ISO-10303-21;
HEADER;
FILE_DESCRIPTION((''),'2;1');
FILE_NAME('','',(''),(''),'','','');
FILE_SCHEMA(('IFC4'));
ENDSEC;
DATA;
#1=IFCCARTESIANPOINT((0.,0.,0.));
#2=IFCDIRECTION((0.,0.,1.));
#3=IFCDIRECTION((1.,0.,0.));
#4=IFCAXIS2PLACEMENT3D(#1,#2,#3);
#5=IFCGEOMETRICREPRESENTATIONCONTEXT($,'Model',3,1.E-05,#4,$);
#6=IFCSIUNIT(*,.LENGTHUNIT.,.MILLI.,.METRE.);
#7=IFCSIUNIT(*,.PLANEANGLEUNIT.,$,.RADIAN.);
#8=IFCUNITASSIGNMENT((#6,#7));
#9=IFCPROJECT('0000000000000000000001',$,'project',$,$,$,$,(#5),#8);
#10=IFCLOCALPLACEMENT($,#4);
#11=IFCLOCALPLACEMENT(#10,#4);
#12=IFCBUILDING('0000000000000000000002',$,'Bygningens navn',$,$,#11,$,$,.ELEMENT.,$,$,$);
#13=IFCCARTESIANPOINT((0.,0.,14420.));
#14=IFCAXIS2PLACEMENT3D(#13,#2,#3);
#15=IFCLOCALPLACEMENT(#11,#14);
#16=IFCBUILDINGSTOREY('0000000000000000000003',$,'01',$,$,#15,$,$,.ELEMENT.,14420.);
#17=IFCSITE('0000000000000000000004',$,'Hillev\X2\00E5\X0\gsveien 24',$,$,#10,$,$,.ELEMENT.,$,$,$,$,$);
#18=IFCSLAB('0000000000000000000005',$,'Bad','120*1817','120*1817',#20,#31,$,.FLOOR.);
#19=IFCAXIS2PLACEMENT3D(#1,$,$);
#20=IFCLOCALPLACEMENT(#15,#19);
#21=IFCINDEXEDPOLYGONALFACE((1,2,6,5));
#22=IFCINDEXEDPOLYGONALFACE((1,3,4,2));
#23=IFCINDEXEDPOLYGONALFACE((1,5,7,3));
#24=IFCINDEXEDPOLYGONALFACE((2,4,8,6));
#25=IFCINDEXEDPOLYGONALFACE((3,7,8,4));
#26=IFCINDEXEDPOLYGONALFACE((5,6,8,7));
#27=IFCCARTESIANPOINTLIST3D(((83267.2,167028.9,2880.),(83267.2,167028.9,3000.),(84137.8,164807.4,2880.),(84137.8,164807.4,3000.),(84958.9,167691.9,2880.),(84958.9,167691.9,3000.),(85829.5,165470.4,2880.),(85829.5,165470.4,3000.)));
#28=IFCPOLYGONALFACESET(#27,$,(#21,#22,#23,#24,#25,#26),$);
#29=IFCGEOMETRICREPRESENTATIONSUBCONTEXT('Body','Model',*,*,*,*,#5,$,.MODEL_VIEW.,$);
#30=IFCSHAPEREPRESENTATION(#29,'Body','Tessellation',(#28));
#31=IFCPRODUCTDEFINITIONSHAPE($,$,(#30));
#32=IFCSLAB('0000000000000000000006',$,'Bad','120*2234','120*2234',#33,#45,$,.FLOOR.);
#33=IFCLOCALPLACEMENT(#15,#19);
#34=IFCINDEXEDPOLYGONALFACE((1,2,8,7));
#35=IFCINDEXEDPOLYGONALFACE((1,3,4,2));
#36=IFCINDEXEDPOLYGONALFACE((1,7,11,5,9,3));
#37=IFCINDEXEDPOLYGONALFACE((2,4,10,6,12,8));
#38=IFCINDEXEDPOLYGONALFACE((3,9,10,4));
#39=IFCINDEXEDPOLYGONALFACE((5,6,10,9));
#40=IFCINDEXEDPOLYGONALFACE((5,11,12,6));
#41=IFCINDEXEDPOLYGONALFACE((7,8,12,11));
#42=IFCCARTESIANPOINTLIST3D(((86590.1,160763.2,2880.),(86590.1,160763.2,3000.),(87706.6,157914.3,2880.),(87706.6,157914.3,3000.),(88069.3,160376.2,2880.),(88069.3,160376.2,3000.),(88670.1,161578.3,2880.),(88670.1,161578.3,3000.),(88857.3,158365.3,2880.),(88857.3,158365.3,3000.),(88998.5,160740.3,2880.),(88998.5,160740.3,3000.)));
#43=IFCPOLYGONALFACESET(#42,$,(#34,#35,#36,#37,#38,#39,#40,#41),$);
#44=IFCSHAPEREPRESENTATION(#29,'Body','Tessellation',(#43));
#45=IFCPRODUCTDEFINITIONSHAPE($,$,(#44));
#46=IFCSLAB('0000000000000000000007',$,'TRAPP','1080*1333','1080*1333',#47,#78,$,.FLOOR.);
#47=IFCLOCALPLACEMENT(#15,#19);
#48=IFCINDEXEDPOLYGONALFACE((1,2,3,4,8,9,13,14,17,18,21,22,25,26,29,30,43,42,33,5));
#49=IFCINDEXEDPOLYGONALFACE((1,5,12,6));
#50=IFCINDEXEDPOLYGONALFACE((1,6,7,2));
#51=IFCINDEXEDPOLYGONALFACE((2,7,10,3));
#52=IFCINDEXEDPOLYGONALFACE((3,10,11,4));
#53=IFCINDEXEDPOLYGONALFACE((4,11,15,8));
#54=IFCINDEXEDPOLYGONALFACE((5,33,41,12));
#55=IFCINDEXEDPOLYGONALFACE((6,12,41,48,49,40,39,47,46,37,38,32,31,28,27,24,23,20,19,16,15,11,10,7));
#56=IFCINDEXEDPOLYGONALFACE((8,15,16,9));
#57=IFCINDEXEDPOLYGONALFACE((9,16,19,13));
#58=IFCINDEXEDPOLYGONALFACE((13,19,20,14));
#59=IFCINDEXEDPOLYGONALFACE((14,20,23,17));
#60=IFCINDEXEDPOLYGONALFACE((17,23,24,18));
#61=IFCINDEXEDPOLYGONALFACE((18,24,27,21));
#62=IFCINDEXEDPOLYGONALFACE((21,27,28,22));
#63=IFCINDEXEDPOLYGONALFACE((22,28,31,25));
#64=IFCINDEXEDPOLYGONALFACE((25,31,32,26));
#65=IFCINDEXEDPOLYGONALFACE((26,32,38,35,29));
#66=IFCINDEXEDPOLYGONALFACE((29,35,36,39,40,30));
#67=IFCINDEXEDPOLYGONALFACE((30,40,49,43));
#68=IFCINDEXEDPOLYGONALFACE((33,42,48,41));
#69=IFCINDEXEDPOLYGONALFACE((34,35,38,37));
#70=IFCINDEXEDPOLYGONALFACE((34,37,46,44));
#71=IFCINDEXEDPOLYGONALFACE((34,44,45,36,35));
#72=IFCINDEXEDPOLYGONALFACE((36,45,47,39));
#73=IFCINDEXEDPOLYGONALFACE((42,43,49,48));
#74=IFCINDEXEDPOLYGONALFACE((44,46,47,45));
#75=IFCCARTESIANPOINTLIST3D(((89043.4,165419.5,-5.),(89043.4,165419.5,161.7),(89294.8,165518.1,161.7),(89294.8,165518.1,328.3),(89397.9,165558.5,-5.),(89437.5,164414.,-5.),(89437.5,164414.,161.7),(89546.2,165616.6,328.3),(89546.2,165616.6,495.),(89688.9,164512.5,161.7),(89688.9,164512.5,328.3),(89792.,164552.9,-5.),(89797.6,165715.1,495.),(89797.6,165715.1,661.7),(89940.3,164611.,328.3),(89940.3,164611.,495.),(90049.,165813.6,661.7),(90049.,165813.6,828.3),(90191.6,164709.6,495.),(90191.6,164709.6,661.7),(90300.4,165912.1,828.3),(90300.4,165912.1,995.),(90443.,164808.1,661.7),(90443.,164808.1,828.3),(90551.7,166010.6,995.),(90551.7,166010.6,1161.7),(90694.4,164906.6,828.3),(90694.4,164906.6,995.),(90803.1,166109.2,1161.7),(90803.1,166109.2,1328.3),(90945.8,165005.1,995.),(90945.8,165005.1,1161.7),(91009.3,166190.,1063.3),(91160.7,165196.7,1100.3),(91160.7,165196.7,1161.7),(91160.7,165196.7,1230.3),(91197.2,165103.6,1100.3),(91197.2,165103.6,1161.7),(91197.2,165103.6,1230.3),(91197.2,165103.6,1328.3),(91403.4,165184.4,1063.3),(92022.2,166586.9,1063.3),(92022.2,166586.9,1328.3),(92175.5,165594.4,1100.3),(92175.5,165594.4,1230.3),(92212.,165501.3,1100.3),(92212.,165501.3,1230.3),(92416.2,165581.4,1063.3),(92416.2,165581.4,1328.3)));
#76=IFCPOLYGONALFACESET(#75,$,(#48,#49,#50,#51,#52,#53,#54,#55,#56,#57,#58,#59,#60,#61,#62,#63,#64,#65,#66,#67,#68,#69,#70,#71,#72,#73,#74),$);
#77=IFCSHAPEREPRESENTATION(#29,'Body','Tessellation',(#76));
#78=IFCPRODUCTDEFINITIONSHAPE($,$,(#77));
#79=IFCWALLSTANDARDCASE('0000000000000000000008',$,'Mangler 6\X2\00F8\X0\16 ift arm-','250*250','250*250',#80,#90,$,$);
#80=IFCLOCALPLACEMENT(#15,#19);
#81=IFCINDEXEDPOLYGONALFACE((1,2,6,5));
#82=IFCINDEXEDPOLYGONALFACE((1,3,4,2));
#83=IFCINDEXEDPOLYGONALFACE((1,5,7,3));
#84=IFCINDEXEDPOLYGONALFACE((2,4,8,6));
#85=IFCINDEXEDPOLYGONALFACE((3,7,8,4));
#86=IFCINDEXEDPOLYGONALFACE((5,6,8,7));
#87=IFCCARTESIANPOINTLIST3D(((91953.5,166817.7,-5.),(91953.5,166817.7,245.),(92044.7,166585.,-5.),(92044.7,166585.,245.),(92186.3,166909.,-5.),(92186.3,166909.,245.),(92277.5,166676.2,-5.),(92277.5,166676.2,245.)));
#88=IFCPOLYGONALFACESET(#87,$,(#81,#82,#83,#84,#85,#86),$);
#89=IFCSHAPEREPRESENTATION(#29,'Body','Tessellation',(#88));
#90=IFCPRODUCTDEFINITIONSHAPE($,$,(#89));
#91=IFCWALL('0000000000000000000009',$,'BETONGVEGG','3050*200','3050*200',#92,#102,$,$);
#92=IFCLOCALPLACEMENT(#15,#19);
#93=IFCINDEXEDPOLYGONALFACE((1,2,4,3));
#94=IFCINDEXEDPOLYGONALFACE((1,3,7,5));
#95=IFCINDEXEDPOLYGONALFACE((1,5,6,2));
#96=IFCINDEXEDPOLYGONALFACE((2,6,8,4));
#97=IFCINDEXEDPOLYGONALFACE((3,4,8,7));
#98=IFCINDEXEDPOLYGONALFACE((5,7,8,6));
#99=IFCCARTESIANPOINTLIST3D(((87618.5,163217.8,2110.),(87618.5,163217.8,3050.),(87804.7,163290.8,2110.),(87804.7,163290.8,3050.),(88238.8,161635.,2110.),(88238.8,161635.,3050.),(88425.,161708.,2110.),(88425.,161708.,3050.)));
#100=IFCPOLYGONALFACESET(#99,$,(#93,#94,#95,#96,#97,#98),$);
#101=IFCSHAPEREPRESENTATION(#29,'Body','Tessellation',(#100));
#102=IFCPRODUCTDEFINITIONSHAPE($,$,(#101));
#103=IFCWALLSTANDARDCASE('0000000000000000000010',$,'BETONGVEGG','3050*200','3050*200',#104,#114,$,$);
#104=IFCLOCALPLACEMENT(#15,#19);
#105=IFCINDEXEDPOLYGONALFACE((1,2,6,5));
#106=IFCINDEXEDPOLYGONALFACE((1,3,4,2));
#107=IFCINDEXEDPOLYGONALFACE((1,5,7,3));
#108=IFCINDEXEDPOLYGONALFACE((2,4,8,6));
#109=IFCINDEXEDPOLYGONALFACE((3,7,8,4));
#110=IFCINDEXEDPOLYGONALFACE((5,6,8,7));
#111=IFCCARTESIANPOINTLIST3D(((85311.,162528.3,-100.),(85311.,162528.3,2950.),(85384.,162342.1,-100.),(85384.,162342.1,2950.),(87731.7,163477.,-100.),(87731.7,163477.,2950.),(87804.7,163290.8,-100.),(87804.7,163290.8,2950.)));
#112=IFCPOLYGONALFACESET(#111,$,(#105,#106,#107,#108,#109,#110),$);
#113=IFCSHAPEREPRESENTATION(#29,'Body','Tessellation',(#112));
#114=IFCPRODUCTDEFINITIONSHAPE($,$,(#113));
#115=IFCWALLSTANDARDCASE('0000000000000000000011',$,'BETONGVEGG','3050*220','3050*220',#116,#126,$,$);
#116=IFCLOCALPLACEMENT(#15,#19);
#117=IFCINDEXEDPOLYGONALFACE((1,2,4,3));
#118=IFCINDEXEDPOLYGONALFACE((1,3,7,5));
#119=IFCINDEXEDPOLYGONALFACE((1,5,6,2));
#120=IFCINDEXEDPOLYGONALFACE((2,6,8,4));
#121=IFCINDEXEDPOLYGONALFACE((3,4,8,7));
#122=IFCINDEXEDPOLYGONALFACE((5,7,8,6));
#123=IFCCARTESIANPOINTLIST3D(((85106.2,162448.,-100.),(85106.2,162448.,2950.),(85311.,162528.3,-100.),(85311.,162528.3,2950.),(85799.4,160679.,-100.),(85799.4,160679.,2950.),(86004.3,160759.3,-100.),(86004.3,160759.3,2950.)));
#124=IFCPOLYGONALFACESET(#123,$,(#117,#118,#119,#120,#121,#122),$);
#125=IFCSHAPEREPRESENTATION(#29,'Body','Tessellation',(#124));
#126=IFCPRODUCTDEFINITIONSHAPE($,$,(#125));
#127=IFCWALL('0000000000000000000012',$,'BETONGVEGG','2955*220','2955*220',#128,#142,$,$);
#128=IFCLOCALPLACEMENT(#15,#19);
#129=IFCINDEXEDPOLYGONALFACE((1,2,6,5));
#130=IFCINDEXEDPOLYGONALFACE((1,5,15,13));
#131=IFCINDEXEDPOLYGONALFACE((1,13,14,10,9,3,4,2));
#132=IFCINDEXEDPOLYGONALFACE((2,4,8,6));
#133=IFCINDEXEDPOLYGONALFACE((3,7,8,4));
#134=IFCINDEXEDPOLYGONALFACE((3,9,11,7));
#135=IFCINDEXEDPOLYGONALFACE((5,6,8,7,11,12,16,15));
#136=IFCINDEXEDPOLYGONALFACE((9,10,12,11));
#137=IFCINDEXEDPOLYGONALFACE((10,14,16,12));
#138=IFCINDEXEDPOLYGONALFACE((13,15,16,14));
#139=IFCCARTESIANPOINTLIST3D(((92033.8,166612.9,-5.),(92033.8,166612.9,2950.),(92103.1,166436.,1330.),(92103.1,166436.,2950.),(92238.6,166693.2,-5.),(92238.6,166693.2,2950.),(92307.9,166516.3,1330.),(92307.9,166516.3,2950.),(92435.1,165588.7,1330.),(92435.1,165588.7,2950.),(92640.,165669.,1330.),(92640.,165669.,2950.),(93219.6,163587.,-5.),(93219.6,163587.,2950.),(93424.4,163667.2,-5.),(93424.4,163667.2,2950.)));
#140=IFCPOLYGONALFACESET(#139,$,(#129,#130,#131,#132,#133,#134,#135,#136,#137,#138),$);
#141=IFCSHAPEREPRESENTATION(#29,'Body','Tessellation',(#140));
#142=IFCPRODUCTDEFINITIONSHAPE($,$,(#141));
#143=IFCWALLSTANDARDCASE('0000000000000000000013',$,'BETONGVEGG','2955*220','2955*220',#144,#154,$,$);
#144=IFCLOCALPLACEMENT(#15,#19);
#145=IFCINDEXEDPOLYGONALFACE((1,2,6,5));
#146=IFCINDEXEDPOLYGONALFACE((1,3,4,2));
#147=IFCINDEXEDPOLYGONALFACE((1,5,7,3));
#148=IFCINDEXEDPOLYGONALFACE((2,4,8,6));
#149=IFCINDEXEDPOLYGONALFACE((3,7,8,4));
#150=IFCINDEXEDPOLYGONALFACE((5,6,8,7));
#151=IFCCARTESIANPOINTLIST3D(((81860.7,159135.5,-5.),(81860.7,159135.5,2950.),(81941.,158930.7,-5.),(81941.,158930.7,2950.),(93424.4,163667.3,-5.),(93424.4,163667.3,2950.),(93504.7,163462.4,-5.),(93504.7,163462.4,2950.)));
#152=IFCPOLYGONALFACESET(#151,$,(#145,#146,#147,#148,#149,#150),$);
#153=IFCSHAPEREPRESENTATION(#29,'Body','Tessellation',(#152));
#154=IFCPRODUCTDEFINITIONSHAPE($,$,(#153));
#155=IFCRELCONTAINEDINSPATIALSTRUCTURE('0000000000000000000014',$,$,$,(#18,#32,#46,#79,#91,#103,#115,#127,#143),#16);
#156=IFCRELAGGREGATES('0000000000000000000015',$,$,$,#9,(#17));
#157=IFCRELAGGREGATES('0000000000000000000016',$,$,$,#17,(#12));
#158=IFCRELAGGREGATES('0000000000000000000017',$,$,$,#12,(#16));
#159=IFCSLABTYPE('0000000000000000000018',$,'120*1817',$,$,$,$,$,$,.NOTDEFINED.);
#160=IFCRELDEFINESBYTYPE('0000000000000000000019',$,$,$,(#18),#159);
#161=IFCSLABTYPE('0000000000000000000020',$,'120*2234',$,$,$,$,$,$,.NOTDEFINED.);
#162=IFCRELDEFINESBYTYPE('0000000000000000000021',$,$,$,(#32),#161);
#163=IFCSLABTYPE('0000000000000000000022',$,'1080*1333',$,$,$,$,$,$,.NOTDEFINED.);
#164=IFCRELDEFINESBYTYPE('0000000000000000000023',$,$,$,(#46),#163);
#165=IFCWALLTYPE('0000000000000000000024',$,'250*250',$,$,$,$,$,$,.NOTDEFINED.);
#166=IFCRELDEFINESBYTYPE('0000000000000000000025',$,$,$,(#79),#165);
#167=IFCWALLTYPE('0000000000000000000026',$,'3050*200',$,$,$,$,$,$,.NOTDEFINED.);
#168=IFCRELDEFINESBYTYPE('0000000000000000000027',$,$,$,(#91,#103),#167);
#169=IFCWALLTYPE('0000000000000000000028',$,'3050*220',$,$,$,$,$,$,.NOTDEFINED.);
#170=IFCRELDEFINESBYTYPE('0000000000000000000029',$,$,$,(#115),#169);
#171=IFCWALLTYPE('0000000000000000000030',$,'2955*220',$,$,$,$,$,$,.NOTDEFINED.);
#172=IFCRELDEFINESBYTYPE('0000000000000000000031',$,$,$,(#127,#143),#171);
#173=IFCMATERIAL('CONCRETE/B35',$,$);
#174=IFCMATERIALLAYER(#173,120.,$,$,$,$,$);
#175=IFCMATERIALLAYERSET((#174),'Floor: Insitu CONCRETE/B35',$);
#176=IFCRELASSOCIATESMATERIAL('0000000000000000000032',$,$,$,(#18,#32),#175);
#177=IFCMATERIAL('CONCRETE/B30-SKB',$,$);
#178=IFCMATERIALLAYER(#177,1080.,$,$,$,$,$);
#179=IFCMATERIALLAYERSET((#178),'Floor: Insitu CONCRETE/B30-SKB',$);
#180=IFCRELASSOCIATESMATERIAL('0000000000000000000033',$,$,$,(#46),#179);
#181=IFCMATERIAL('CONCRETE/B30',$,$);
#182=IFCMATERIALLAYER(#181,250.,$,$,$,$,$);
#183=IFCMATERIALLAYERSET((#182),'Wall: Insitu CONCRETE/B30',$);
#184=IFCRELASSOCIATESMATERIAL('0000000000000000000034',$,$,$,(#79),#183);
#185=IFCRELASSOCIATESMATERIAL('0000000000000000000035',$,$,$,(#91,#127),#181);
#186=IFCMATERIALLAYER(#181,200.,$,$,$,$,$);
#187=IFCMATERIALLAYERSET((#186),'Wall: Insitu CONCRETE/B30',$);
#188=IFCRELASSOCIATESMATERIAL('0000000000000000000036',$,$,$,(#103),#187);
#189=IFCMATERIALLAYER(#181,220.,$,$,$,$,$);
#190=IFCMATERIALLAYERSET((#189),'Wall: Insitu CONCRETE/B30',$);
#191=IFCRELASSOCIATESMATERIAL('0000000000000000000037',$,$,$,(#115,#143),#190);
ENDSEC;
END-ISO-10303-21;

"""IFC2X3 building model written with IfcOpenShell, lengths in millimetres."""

from ifc_helpers import new_model, si_unit, frame, frame_2d, origin_with_axes, place, context, subcontext, project, spatial, polyline, rectangle, outline, extrude, boolean, material, layer, layer_set, layer_usage, type_object, element, save


model = new_model("IFC2X3")

# Units and contexts
model_context = context("Model", 3, precision=1e-05, world=origin_with_axes())
body_context = subcontext(model_context, "Body", "Model", "MODEL_VIEW")
ifc_project = project(units=[si_unit("LENGTHUNIT", "METRE", prefix="MILLI"), si_unit("PLANEANGLEUNIT", "RADIAN")], contexts=[model_context])

# Site, building, storey
site_placement = place(None, origin_with_axes())
site = spatial("IfcSite", under=ifc_project, at=site_placement, Name="Hillevågsveien 24", CompositionType="ELEMENT")
building_placement = place(site_placement, origin_with_axes())
building = spatial("IfcBuilding", under=site, at=building_placement, Name="Bygningens navn", CompositionType="ELEMENT")
storey_placement = place(building_placement, frame((0.0, 0.0, 14420.0), z_axis=(0.0, 0.0, 1.0), x_axis=(1.0, 0.0, 0.0)))
storey = spatial("IfcBuildingStorey", under=building, at=storey_placement, Name="01", CompositionType="ELEMENT", Elevation=14420.0)

# Slabs
ifc_material_1 = material(Name="CONCRETE/B35")
ifc_layer_1 = layer(ifc_material_1, 120.0)
ifc_layer_set_1 = layer_set([ifc_layer_1], Name="Floor: Insitu CONCRETE/B35")
ifc_layer_usage_1 = layer_usage(ifc_layer_set_1, "AXIS3", "POSITIVE", -60.0)
slab_type_1 = type_object("IfcSlabType", Name="120*1817", PredefinedType="NOTDEFINED")
slab_1_placement = place(storey_placement, frame((85829.5, 165470.4, 2940.0), z_axis=(0.0, 0.0, -1.0), x_axis=(-0.931056, -0.364877, 0.0)))
element("IfcSlab", 1, at=slab_1_placement, inside=storey, type_object=slab_type_1, material=ifc_layer_usage_1, Name="Bad", Description="120*1817", ObjectType="120*1817", PredefinedType="FLOOR", context=body_context, shape_type="SweptSolid", body=[
    extrude(outline(polyline([(0.0, 0.0), (1817.0, 0.0), (1817.0, 2386.0), (0.0, 2386.0), (0.0, 0.0)])), frame((0.0, 0.0, -60.0), z_axis=(0.0, 0.0, 1.0), x_axis=(1.0, 0.0, 0.0)), (0.0, 0.0, 1.0), 120.0),
])
ifc_layer_usage_2 = layer_usage(ifc_layer_set_1, "AXIS3", "POSITIVE", -60.0)
slab_type_2 = type_object("IfcSlabType", Name="120*2234", PredefinedType="NOTDEFINED")
slab_2_placement = place(storey_placement, frame((88069.3, 160376.2, 2940.0), z_axis=(0.0, 0.0, -1.0), x_axis=(0.364877, -0.931056, 0.0)))
element("IfcSlab", 2, at=slab_2_placement, inside=storey, type_object=slab_type_2, material=ifc_layer_usage_2, Name="Bad", Description="120*2234", ObjectType="120*2234", PredefinedType="FLOOR", context=body_context, shape_type="SweptSolid", body=[
    extrude(outline(polyline([(0.0, 0.0), (2159.8, 0.0), (2159.8, 1236.0), (-900.0, 1236.0), (-900.0, -998.0), (0.0, -998.0), (0.0, 0.0)])), frame((0.0, 0.0, -60.0), z_axis=(0.0, 0.0, 1.0), x_axis=(1.0, 0.0, 0.0)), (0.0, 0.0, 1.0), 120.0),
])
ifc_material_2 = material(Name="CONCRETE/B30")
ifc_material_3 = material(Name="CONCRETE/B30-SKB")
ifc_layer_2 = layer(ifc_material_3, 1080.0)
ifc_layer_set_2 = layer_set([ifc_layer_2], Name="Floor: Insitu CONCRETE/B30-SKB")
ifc_layer_usage_3 = layer_usage(ifc_layer_set_2, "AXIS3", "POSITIVE", -540.0)
slab_type_3 = type_object("IfcSlabType", Name="1080*1333", PredefinedType="NOTDEFINED")
slab_3_placement = place(storey_placement, frame((89240.5, 164916.8, 161.7), z_axis=(-0.364877, 0.931056, 0.0), x_axis=(0.931056, 0.364877, 0.0)))
element("IfcSlab", 3, at=slab_3_placement, inside=storey, type_object=slab_type_3, material=ifc_layer_usage_3, Name="TRAPP", Description="1080*1333", ObjectType="1080*1333", PredefinedType="FLOOR", context=body_context, shape_type="CSG", body=[
    boolean("DIFFERENCE", extrude(outline(polyline([(0.0, 0.0), (270.0, 0.0), (270.0, -166.7), (540.0, -166.7), (540.0, -333.3), (810.0, -333.3), (810.0, -500.0), (1080.0, -500.0), (1080.0, -666.7), (1350.0, -666.7), (1350.0, -833.3), (1620.0, -833.3), (1620.0, -1000.0), (1890.0, -1000.0), (1890.0, -1166.7), (3199.3, -1166.7), (3199.3, -901.7), (2111.5, -901.7), (380.8, 166.7), (0.0, 166.7), (0.0, 0.0)])), frame((0.0, 0.0, -540.0), z_axis=(0.0, 0.0, 1.0), x_axis=(1.0, 0.0, 0.0)), (0.0, 0.0, 1.0), 1080.0), extrude(rectangle(XDim=105.0, YDim=130.0, at=frame_2d((0.0, 0.0), x_axis=(1.0, 0.0))), frame((1890.0, -1003.6, -492.5), z_axis=(1.0, 0.0, 0.000001), x_axis=(-0.000001, -0.000001, 1.0)), (0.0, 0.0, 1.0), 1090.0)),
])

# Walls
ifc_layer_3 = layer(ifc_material_2, 250.0)
ifc_layer_set_3 = layer_set([ifc_layer_3], Name="Wall: Insitu CONCRETE/B30")
ifc_layer_usage_4 = layer_usage(ifc_layer_set_3, "AXIS2", "POSITIVE", -125.0)
wall_type_1 = type_object("IfcWallType", Name="250*250", PredefinedType="NOTDEFINED")
wall_1_placement = place(storey_placement, frame((92161.1, 166630.6, -5.0), z_axis=(0.0, 0.0, 1.0), x_axis=(-0.364877, 0.931056, 0.0)))
element("IfcWallStandardCase", 4, at=wall_1_placement, inside=storey, type_object=wall_type_1, material=ifc_layer_usage_4, Name="Mangler 6ø16 ift arm-", Description="250*250", ObjectType="250*250", context=body_context, shape_type="SweptSolid", body=[
    extrude(rectangle(XDim=250.0, YDim=250.0, at=frame_2d((0.0, 125.0), x_axis=(0.0, -1.0))), frame((0.0, 0.0, 0.0), z_axis=(0.0, 0.0, 1.0), x_axis=(0.0, -1.0, 0.0)), (0.0, 0.0, 1.0), 250.0),
])
wall_type_2 = type_object("IfcWallType", Name="3050*200", PredefinedType="NOTDEFINED")
wall_2_placement = place(storey_placement, frame((88331.9, 161671.5, 1055.0), z_axis=(0.0, 0.0, 1.0), x_axis=(-0.364878, 0.931055, 0.0)))
element("IfcWall", 5, at=wall_2_placement, inside=storey, type_object=wall_type_2, material=ifc_material_2, Name="BETONGVEGG", Description="3050*200", ObjectType="3050*200", context=body_context, shape_type="CSG", body=[
    boolean("DIFFERENCE", extrude(rectangle(XDim=1700.0, YDim=200.0, at=frame_2d((0.0, 850.0), x_axis=(0.0, -1.0))), frame((0.0, 0.0, -1055.0), z_axis=(0.0, 0.0, 1.0), x_axis=(0.0, -1.0, 0.0)), (0.0, 0.0, 1.0), 3050.0), extrude(rectangle(XDim=1700.0, YDim=500.0, at=frame_2d((0.0, 850.0), x_axis=(0.0, -1.0))), frame((0.0, -99.9, -1055.0), z_axis=(0.0, 0.0, 1.0), x_axis=(-0.000031, -1.0, 0.0)), (0.0, 0.0, 1.0), 2110.0)),
])
ifc_layer_4 = layer(ifc_material_2, 200.0)
ifc_layer_set_4 = layer_set([ifc_layer_4], Name="Wall: Insitu CONCRETE/B30")
ifc_layer_usage_5 = layer_usage(ifc_layer_set_4, "AXIS2", "POSITIVE", -100.0)
wall_3_placement = place(storey_placement, frame((85347.5, 162435.2, -100.0), z_axis=(0.0, 0.0, 1.0), x_axis=(0.931056, 0.364876, 0.0)))
element("IfcWallStandardCase", 6, at=wall_3_placement, inside=storey, type_object=wall_type_2, material=ifc_layer_usage_5, Name="BETONGVEGG", Description="3050*200", ObjectType="3050*200", context=body_context, shape_type="SweptSolid", body=[
    extrude(rectangle(XDim=2599.9, YDim=200.0, at=frame_2d((0.0, 1300.0), x_axis=(0.0, -1.0))), frame((0.0, 0.0, 0.0), z_axis=(0.0, 0.0, 1.0), x_axis=(0.0, -1.0, 0.0)), (0.0, 0.0, 1.0), 3050.0),
])
ifc_layer_5 = layer(ifc_material_2, 220.0)
ifc_layer_set_5 = layer_set([ifc_layer_5], Name="Wall: Insitu CONCRETE/B30")
ifc_layer_usage_6 = layer_usage(ifc_layer_set_5, "AXIS2", "POSITIVE", -110.0)
wall_type_3 = type_object("IfcWallType", Name="3050*220", PredefinedType="NOTDEFINED")
wall_4_placement = place(storey_placement, frame((85208.6, 162488.2, -100.0), z_axis=(0.0, 0.0, 1.0), x_axis=(0.364878, -0.931056, 0.0)))
element("IfcWallStandardCase", 7, at=wall_4_placement, inside=storey, type_object=wall_type_3, material=ifc_layer_usage_6, Name="BETONGVEGG", Description="3050*220", ObjectType="3050*220", context=body_context, shape_type="SweptSolid", body=[
    extrude(rectangle(XDim=1900.0, YDim=220.0, at=frame_2d((0.0, 950.0), x_axis=(0.0, -1.0))), frame((0.0, 0.0, 0.0), z_axis=(0.0, 0.0, 1.0), x_axis=(0.0, -1.0, 0.0)), (0.0, 0.0, 1.0), 3050.0),
])
wall_type_4 = type_object("IfcWallType", Name="2955*220", PredefinedType="NOTDEFINED")
wall_5_placement = place(storey_placement, frame((93322.0, 163627.1, -5.0), z_axis=(0.0, 0.0, 1.0), x_axis=(-0.364877, 0.931056, 0.0)))
element("IfcWall", 8, at=wall_5_placement, inside=storey, type_object=wall_type_4, material=ifc_material_2, Name="BETONGVEGG", Description="2955*220", ObjectType="2955*220", context=body_context, shape_type="CSG", body=[
    boolean("DIFFERENCE", extrude(rectangle(XDim=3250.0, YDim=220.0, at=frame_2d((0.0, 1625.0), x_axis=(0.0, -1.0))), frame((0.0, 0.0, 0.0), z_axis=(0.0, 0.0, 1.0), x_axis=(0.0, -1.0, 0.0)), (0.0, 0.0, 1.0), 2955.0), extrude(rectangle(XDim=910.0, YDim=500.0, at=frame_2d((0.0, 455.0), x_axis=(0.0, -1.0))), frame((2150.0, 0.0, 1335.0), z_axis=(0.0, 0.0, 1.0), x_axis=(-0.000002, -1.0, 0.0)), (0.0, 0.0, 1.0), 2210.0)),
])
ifc_layer_usage_7 = layer_usage(ifc_layer_set_5, "AXIS2", "POSITIVE", -110.0)
wall_6_placement = place(storey_placement, frame((81900.9, 159033.1, -5.0), z_axis=(0.0, 0.0, 1.0), x_axis=(0.931056, 0.364877, 0.0)))
element("IfcWallStandardCase", 9, at=wall_6_placement, inside=storey, type_object=wall_type_4, material=ifc_layer_usage_7, Name="BETONGVEGG", Description="2955*220", ObjectType="2955*220", context=body_context, shape_type="SweptSolid", body=[
    extrude(rectangle(XDim=12420.0, YDim=220.0, at=frame_2d((0.0, 6210.0), x_axis=(0.0, -1.0))), frame((0.0, 0.0, 0.0), z_axis=(0.0, 0.0, 1.0), x_axis=(0.0, -1.0, 0.0)), (0.0, 0.0, 1.0), 2955.0),
])

save(model, "model.ifc")
